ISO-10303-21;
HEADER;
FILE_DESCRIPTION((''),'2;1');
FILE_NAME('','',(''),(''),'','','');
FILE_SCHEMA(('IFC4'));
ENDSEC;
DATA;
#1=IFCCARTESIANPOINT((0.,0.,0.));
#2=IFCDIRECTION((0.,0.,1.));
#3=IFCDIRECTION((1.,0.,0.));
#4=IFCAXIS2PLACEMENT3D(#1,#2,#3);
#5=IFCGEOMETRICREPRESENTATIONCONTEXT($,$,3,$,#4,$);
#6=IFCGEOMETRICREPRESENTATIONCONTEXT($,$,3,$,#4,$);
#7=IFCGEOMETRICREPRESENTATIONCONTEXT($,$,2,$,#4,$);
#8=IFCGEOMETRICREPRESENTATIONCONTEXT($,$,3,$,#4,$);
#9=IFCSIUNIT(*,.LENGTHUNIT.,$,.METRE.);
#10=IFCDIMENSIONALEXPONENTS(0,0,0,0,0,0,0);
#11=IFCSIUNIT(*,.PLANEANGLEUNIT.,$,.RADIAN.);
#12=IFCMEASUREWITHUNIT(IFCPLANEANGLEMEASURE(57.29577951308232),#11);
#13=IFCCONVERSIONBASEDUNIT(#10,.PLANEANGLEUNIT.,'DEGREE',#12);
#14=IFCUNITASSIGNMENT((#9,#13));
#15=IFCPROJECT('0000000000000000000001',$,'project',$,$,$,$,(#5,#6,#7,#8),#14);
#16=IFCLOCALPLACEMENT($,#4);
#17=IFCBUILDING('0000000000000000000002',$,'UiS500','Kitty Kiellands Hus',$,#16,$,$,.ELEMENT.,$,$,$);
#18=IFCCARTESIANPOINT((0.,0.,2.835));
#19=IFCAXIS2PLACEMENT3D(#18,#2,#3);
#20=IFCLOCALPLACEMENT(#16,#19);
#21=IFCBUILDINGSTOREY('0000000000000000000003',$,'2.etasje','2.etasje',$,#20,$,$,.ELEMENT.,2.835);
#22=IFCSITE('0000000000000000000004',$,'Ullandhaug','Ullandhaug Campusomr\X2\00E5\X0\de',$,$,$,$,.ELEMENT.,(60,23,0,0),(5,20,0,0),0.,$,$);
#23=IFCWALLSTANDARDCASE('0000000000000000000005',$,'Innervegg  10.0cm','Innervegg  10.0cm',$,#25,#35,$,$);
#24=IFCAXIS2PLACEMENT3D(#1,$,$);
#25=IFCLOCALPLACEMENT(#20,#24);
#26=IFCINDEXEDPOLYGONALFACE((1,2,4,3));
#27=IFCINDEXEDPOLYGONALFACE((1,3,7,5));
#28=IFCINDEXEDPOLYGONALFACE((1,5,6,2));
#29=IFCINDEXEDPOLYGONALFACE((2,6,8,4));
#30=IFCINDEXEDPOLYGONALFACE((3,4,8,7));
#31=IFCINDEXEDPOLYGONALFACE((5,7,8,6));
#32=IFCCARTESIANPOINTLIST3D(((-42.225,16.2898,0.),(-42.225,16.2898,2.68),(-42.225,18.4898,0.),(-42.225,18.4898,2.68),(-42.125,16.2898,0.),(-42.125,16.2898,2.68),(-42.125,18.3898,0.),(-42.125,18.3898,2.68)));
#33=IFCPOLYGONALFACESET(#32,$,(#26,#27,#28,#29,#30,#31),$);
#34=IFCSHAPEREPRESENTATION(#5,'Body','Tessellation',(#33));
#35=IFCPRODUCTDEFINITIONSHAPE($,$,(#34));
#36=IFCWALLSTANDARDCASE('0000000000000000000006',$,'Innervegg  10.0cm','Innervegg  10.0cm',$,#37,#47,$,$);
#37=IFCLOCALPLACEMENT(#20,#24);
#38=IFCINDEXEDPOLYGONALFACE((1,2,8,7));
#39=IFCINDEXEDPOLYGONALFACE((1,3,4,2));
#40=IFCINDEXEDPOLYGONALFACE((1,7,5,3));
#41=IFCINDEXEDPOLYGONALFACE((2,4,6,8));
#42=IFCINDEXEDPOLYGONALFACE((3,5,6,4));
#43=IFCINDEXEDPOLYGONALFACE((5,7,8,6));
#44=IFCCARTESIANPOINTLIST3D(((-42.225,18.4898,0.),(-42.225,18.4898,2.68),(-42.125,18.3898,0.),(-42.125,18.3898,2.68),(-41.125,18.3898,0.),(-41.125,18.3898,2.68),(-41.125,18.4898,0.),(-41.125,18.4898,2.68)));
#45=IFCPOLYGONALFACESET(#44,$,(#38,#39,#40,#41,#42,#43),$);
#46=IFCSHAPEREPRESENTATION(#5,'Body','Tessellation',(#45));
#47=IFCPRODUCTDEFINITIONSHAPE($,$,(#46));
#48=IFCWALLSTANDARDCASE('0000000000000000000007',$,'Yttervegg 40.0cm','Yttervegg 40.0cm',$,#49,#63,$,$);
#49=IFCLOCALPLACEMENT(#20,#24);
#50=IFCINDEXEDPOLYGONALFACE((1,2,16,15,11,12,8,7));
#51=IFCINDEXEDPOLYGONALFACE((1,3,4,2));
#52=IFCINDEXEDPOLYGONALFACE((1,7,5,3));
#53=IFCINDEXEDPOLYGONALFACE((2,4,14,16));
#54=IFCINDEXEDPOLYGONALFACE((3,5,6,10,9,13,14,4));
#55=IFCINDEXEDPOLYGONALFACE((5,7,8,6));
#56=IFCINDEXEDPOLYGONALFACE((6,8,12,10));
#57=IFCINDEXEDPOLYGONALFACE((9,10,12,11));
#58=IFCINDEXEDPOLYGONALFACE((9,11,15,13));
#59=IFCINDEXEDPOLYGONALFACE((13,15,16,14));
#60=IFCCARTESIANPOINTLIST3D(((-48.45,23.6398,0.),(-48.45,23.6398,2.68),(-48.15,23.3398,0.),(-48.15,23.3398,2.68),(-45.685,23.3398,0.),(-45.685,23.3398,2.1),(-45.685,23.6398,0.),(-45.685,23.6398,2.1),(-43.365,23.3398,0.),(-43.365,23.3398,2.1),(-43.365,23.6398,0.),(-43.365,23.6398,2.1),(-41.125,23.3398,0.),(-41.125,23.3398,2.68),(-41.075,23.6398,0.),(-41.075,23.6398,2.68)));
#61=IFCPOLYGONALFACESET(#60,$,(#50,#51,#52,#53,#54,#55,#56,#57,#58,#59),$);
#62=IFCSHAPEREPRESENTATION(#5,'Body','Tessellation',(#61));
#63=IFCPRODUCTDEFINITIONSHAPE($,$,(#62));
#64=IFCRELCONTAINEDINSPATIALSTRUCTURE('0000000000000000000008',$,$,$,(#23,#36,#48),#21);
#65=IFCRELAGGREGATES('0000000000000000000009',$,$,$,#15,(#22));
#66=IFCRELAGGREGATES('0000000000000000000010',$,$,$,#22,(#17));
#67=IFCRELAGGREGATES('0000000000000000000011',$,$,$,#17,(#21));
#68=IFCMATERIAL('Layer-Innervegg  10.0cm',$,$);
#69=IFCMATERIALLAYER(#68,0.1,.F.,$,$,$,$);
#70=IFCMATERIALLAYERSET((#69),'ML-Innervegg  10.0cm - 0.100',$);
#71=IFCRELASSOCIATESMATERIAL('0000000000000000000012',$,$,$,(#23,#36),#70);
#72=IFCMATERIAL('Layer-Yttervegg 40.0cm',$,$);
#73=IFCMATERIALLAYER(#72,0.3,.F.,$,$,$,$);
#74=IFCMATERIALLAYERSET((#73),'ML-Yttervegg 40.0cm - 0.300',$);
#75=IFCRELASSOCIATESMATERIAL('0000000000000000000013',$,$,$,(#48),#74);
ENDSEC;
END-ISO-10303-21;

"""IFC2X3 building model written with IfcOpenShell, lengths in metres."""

from ifc_helpers import new_model, entity, si_unit, converted_unit, frame, origin_with_axes, place, context, project, spatial, polyline, outline, extrude, material, layer, layer_set, layer_usage, element, save


model = new_model("IFC2X3")

# Units and contexts
context_of_model_1 = context(None, 3, world=origin_with_axes())
context_of_model_2 = context(None, 3, world=origin_with_axes())
context_of_model_3 = context(None, 2, world=origin_with_axes())
context_of_model_4 = context(None, 3, world=origin_with_axes())
ifc_project = project(units=[si_unit("LENGTHUNIT", "METRE"), converted_unit("PLANEANGLEUNIT", "DEGREE", entity("IfcPlaneAngleMeasure", 57.29577951308232), si_unit("PLANEANGLEUNIT", "RADIAN"), dimensions=[0, 0, 0, 0, 0, 0, 0])], contexts=[context_of_model_1, context_of_model_2, context_of_model_3, context_of_model_4])

# Site, building, storey
site = spatial("IfcSite", under=ifc_project, Name="Ullandhaug", Description="Ullandhaug Campusområde", CompositionType="ELEMENT", RefLatitude=(60, 23, 0, 0), RefLongitude=(5, 20, 0, 0), RefElevation=0.0)
building_placement = place(None, origin_with_axes())
building = spatial("IfcBuilding", under=site, at=building_placement, Name="UiS500", Description="Kitty Kiellands Hus", CompositionType="ELEMENT")
storey_placement = place(building_placement, frame((0.0, 0.0, 2.835), z_axis=(0.0, 0.0, 1.0), x_axis=(1.0, 0.0, 0.0)))
storey = spatial("IfcBuildingStorey", under=building, at=storey_placement, Name="2.etasje", Description="2.etasje", CompositionType="ELEMENT", Elevation=2.835)

# Shared definitions
ifc_material_1 = material(Name="Layer-Yttervegg 40.0cm")
ifc_layer_1 = layer(ifc_material_1, 0.3, ventilated=False)
ifc_layer_set_1 = layer_set([ifc_layer_1], Name="ML-Yttervegg 40.0cm - 0.300")
ifc_layer_usage_1 = layer_usage(ifc_layer_set_1, "AXIS2", "POSITIVE", 0.0)

# Walls
ifc_material_2 = material(Name="Layer-Innervegg  10.0cm")
ifc_layer_2 = layer(ifc_material_2, 0.1, ventilated=False)
ifc_layer_set_2 = layer_set([ifc_layer_2], Name="ML-Innervegg  10.0cm - 0.100")
ifc_layer_usage_2 = layer_usage(ifc_layer_set_2, "AXIS2", "POSITIVE", 0.0)
wall_1_placement = place(storey_placement, frame((-42.125, 16.2898, 0.0), z_axis=(0.0, 0.0, 1.0), x_axis=(0.0, 1.0, 0.0)))
element("IfcWallStandardCase", 1, at=wall_1_placement, inside=storey, material=ifc_layer_usage_2, Name="Innervegg  10.0cm", Description="Innervegg  10.0cm", context=context_of_model_1, shape_type="SweptSolid", body=[
    extrude(outline(polyline([(0.0, 0.0), (2.1, 0.0), (2.2, 0.1), (0.0, 0.1), (0.0, 0.0)])), frame((0.0, 0.0, 0.0), z_axis=(0.0, 0.0, 1.0), x_axis=(1.0, 0.0, 0.0)), (0.0, 0.0, 1.0), 2.68),
])
wall_2_placement = place(storey_placement, frame((-42.125, 18.3898, 0.0), z_axis=(0.0, 0.0, 1.0), x_axis=(1.0, 0.0, 0.0)))
element("IfcWallStandardCase", 2, at=wall_2_placement, inside=storey, material=ifc_layer_usage_2, Name="Innervegg  10.0cm", Description="Innervegg  10.0cm", context=context_of_model_1, shape_type="SweptSolid", body=[
    extrude(outline(polyline([(0.0, 0.0), (1.0, 0.0), (1.0, 0.1), (-0.1, 0.1), (0.0, 0.0)])), origin_with_axes(), (0.0, 0.0, 1.0), 2.68),
])

# Wall, opening
wall_3_placement = place(storey_placement, frame((-41.075, 23.6398, 0.0), z_axis=(0.0, 0.0, 1.0), x_axis=(-1.0, 0.0, 0.0)))
wall_3 = element("IfcWallStandardCase", 3, at=wall_3_placement, inside=storey, material=ifc_layer_usage_1, Name="Yttervegg 40.0cm", Description="Yttervegg 40.0cm", context=context_of_model_1, shape_type="SweptSolid", body=[
    extrude(outline(polyline([(0.0, 0.0), (7.375, 0.0), (7.075, 0.3), (0.05, 0.3), (0.0, 0.0)])), frame((0.0, 0.0, 0.0), z_axis=(0.0, 0.0, 1.0), x_axis=(1.0, 0.0, 0.0)), (0.0, 0.0, 1.0), 2.68),
])
opening_1_placement = place(wall_3_placement, frame((2.29, 0.3, 0.0), z_axis=(0.0, 0.0, 1.0), x_axis=(1.0, 0.0, 0.0)))
element("IfcOpeningElement", 4, at=opening_1_placement, cuts=wall_3, context=context_of_model_1, shape_type="SweptSolid", body=[
    extrude(outline(polyline([(0.0, 0.0), (2.1, 0.0), (2.1, 2.32), (0.0, 2.32), (0.0, 0.0)])), frame((0.0, 0.0, 0.0), z_axis=(0.0, 1.0, 0.0), x_axis=(0.0, 0.0, 1.0)), (0.0, 0.0, -1.0), 0.3),
])

save(model, "model.ifc")
